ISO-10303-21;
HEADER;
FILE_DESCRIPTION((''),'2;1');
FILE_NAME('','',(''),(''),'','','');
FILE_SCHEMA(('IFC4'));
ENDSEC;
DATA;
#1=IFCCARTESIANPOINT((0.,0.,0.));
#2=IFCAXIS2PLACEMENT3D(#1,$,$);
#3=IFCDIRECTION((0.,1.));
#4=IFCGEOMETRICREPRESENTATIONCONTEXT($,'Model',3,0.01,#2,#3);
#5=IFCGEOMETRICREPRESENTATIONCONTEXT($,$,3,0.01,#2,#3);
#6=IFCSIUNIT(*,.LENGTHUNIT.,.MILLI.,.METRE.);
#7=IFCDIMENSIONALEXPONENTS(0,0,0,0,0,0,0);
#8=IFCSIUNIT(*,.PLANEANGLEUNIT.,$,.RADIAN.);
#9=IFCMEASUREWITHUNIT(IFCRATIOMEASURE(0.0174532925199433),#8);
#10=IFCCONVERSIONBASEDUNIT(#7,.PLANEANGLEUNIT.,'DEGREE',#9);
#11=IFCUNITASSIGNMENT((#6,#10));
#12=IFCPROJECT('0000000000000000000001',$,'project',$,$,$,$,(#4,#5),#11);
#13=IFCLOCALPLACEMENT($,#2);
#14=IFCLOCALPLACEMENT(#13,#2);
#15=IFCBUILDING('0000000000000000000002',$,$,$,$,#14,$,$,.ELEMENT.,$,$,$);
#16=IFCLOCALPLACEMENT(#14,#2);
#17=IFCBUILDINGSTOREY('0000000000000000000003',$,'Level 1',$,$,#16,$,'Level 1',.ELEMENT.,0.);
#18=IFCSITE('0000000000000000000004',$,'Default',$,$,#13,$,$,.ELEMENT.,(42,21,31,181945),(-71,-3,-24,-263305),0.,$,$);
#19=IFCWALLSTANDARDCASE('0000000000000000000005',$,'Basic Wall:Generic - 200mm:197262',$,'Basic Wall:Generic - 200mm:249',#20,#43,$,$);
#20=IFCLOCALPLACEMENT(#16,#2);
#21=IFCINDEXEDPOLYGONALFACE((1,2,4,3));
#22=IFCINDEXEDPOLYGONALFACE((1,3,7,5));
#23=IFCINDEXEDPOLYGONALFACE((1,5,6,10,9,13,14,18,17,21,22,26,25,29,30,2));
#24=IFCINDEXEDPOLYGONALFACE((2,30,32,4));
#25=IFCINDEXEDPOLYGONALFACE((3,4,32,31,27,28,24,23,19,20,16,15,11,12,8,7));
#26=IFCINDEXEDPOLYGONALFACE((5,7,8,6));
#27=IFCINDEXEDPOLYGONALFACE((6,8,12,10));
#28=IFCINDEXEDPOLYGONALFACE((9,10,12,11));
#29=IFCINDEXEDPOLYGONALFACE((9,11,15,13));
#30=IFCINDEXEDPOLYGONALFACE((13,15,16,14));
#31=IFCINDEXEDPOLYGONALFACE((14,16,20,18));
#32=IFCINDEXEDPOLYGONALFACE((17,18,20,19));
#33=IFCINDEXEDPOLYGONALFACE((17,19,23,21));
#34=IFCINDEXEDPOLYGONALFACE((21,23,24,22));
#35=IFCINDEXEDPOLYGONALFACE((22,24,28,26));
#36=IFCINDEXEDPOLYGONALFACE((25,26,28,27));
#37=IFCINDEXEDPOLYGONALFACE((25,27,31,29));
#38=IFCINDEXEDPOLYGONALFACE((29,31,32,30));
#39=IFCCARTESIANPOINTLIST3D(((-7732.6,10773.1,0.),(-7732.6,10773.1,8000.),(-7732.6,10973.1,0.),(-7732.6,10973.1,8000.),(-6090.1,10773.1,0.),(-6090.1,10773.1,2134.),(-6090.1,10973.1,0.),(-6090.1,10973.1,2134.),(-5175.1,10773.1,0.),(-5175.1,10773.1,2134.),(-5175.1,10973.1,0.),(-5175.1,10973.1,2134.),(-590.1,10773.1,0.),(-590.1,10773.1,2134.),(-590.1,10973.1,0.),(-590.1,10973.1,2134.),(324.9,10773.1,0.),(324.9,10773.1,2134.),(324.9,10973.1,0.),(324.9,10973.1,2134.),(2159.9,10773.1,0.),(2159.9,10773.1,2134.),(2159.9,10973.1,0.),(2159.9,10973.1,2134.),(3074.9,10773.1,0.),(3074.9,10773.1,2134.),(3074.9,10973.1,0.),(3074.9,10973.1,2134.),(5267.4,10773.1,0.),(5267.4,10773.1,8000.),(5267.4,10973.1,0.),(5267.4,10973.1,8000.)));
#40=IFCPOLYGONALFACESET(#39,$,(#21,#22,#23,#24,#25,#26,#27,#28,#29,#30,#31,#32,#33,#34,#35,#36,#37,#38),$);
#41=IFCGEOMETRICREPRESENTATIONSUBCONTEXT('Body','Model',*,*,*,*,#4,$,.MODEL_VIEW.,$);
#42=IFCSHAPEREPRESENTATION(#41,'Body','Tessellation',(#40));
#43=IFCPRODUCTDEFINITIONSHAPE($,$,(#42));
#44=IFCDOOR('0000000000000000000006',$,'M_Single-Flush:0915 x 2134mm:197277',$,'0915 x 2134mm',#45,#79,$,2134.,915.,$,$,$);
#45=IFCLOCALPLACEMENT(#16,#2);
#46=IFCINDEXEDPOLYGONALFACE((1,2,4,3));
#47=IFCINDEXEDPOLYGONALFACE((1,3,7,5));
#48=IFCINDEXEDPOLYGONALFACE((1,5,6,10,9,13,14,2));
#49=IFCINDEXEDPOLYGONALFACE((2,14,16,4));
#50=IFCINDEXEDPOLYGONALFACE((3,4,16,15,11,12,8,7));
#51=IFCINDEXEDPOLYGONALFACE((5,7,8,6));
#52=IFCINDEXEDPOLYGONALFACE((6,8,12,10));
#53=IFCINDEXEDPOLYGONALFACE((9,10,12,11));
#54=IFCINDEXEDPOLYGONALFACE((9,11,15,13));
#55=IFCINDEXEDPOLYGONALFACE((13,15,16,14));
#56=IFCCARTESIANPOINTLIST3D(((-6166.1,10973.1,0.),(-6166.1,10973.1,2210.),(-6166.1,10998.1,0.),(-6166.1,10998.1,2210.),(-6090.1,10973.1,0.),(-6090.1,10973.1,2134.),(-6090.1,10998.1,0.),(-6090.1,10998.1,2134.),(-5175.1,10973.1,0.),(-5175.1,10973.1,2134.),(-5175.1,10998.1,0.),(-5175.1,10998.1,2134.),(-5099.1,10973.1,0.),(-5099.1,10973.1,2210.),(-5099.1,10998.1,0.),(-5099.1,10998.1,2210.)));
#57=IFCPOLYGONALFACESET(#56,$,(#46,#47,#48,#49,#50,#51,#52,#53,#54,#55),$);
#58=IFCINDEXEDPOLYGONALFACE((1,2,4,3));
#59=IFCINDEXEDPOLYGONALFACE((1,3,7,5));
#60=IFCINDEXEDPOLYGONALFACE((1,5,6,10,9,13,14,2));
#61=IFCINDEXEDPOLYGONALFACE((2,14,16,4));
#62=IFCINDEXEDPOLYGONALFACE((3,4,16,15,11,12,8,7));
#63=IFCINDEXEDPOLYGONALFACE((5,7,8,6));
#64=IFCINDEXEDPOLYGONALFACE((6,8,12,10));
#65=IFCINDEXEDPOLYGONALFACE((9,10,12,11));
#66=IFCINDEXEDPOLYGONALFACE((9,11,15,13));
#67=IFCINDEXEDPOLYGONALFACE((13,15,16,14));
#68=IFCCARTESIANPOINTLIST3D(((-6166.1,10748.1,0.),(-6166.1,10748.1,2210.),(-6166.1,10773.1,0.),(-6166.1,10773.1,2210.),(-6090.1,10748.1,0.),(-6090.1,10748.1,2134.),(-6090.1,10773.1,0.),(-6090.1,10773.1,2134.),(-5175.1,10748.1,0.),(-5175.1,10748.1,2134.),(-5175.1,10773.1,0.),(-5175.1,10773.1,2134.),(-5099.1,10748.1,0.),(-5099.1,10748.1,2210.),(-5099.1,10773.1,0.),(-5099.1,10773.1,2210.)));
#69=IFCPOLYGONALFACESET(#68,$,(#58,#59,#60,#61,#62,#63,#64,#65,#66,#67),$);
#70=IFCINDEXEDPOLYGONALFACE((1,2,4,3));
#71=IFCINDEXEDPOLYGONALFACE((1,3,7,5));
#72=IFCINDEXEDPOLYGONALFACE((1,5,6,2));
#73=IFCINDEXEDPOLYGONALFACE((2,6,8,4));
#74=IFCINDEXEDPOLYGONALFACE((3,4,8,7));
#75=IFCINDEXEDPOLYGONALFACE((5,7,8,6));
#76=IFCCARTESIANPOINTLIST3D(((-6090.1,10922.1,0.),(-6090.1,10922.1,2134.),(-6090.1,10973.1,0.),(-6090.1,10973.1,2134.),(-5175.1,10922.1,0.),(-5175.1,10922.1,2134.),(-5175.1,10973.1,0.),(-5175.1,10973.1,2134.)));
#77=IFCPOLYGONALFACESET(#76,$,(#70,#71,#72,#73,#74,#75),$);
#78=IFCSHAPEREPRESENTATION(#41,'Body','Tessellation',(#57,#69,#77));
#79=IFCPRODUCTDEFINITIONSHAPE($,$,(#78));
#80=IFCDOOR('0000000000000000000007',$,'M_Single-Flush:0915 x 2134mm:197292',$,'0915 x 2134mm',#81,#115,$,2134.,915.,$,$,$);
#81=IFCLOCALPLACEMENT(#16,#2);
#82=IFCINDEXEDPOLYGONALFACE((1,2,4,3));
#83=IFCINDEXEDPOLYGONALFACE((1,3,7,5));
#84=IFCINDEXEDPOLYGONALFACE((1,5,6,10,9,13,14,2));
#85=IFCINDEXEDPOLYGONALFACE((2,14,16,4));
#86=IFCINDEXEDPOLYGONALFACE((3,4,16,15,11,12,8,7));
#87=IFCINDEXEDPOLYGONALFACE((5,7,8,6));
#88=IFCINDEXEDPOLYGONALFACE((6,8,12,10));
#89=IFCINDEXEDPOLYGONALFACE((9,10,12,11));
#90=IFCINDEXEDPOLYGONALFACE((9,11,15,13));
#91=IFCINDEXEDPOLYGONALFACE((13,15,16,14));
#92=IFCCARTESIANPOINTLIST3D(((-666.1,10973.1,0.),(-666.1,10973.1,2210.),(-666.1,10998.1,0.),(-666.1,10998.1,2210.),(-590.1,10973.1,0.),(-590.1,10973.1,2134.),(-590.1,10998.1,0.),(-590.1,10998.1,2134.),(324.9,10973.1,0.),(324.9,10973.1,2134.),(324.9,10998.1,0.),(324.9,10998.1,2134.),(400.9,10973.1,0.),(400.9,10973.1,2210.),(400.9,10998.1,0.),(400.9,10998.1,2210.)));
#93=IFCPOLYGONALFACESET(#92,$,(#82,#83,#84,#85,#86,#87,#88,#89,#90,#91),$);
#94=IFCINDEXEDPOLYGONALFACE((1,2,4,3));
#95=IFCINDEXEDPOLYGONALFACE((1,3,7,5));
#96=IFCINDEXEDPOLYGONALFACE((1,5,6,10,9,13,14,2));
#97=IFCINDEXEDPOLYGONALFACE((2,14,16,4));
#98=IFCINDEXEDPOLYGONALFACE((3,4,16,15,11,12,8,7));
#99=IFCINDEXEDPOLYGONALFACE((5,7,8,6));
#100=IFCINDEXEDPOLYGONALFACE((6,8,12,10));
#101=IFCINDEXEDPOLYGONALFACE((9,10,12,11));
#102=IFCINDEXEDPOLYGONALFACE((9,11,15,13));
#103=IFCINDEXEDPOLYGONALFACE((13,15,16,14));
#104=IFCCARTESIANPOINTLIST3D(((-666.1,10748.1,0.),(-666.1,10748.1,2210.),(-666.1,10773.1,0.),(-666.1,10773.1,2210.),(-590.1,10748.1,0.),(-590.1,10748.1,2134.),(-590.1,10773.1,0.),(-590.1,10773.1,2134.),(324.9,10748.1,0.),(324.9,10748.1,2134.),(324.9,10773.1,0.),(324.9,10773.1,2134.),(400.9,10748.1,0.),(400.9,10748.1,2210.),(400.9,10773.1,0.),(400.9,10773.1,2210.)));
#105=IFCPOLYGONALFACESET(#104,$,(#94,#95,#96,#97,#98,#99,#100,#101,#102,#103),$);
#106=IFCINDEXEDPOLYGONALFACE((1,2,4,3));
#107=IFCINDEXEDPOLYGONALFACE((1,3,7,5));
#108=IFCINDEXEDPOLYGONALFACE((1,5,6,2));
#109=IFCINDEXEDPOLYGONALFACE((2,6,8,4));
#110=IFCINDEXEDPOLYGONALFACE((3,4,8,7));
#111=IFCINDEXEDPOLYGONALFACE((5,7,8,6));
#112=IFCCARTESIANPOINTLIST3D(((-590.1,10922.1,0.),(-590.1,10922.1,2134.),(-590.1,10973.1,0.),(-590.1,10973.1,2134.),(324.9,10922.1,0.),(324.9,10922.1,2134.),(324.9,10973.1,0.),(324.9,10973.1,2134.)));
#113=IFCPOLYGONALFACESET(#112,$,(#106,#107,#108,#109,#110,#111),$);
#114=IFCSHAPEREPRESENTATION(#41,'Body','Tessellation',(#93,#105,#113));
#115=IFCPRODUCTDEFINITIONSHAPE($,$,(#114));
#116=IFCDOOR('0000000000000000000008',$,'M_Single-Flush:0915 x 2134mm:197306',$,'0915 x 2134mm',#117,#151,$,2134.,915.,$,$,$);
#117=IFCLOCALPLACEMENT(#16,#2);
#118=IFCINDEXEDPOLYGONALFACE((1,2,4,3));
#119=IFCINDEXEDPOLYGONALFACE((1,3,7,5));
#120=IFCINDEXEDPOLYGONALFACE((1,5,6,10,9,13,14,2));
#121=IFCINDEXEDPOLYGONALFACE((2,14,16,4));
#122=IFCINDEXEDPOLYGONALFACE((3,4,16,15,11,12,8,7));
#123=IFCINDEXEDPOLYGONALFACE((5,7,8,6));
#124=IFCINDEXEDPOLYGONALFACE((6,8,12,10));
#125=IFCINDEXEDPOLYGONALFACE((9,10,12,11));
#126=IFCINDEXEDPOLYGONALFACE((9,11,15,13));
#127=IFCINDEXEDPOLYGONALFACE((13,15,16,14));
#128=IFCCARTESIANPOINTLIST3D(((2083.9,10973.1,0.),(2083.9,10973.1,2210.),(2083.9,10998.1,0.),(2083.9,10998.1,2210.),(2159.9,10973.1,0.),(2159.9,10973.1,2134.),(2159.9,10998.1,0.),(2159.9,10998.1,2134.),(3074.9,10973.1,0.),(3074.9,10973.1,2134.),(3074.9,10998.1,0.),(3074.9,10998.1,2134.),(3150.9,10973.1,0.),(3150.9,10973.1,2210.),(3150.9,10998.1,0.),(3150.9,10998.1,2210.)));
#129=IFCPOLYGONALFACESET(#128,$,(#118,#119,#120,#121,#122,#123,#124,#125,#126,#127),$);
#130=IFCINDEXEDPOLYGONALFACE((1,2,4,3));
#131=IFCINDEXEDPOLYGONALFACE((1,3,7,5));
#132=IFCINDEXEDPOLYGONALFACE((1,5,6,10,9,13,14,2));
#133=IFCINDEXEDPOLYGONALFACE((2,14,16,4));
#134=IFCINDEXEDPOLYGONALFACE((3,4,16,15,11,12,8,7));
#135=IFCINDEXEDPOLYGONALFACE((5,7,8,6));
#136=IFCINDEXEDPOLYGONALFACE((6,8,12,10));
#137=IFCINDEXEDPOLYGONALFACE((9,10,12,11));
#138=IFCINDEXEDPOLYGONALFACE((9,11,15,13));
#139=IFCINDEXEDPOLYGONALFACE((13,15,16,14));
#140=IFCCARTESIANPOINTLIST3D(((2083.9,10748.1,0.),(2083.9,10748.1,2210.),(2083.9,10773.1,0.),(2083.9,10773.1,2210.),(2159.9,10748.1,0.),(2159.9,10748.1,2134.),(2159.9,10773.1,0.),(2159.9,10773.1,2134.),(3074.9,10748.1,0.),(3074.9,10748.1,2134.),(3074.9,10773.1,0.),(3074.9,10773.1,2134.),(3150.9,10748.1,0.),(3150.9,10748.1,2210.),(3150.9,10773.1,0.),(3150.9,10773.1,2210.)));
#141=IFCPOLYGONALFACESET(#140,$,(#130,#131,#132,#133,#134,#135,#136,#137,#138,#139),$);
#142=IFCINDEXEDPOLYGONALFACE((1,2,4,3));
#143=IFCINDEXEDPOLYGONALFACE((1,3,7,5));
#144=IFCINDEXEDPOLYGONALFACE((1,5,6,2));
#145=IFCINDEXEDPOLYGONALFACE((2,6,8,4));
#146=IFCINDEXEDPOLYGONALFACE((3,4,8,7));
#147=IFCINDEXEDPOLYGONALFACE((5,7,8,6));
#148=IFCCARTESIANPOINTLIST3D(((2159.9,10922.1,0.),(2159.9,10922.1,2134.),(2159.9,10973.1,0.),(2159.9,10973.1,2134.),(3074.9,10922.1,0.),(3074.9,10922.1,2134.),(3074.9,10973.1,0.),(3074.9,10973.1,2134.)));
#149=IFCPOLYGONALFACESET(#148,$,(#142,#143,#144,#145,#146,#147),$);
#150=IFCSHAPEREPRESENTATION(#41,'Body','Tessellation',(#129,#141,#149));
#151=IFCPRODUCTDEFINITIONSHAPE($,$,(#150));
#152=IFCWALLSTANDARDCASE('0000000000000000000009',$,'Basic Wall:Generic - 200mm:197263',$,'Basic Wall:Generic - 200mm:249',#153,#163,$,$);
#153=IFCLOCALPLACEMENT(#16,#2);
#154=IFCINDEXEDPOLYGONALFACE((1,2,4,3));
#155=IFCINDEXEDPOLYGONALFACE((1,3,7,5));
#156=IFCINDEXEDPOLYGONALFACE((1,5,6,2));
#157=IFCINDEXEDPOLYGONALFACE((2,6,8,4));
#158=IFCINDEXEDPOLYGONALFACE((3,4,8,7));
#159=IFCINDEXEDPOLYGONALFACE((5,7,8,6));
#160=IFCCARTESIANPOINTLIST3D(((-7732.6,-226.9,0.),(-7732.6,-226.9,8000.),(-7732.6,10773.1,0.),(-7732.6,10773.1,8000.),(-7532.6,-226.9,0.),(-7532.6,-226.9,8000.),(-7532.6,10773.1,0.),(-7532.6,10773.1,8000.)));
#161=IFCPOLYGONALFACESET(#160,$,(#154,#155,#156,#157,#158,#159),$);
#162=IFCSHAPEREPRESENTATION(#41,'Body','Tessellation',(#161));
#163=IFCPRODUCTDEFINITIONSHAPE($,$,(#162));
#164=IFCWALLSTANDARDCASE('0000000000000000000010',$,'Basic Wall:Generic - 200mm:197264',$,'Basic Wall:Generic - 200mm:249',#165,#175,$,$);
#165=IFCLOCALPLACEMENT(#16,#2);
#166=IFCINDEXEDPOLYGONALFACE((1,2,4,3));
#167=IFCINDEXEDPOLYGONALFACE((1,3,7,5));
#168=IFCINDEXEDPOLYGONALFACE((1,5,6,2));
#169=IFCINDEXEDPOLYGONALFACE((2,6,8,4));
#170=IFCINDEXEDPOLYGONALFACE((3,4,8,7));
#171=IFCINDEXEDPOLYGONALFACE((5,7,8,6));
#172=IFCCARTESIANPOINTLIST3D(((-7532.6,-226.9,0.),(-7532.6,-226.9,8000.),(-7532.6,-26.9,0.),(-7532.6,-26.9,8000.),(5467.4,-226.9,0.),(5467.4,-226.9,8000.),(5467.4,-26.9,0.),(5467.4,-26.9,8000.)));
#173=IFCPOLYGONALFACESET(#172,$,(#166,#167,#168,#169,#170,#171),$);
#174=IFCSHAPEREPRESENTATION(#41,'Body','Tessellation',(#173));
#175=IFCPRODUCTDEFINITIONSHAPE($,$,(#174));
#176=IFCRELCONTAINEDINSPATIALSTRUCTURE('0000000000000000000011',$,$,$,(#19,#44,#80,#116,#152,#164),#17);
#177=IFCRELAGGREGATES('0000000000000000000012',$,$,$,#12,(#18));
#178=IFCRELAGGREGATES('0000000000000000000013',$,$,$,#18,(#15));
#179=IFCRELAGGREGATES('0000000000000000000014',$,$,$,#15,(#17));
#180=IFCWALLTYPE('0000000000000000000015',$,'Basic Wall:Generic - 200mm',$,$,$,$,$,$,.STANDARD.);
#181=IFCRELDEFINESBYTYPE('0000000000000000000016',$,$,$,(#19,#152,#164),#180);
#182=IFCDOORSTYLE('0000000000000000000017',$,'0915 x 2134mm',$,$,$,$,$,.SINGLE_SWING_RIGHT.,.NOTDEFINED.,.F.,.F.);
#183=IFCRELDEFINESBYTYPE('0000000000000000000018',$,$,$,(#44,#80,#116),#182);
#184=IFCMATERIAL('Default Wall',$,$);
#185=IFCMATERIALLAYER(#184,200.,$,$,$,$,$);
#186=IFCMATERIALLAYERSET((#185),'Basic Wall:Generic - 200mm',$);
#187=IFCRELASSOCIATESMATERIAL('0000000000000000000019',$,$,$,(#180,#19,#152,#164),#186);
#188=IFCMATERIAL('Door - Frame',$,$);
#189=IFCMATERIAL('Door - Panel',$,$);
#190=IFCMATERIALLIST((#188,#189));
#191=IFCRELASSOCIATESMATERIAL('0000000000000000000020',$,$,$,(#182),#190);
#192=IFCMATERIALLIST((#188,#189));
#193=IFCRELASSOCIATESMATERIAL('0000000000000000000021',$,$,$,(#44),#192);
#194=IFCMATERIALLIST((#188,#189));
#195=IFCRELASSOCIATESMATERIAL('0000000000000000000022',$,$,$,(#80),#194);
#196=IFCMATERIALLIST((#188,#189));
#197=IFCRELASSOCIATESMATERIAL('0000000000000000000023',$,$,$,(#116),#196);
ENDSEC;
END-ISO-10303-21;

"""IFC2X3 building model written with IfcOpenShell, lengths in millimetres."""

from ifc_helpers import new_model, entity, si_unit, converted_unit, direction, frame, frame_2d, origin, place, context, subcontext, project, spatial, polyline, rectangle, outline, extrude, source, transform, mapped, material, material_list, layer, layer_set, layer_usage, type_object, type_shapes, element, fill, save


model = new_model("IFC2X3")

# Units and contexts
model_context = context("Model", 3, precision=0.01, world=origin(), true_north=direction((0.0, 1.0)))
context_of_model = context(None, 3, precision=0.01, world=origin(), true_north=direction((0.0, 1.0)))
body_context = subcontext(model_context, "Body", "Model", "MODEL_VIEW")
ifc_project = project(units=[si_unit("LENGTHUNIT", "METRE", prefix="MILLI"), converted_unit("PLANEANGLEUNIT", "DEGREE", entity("IfcRatioMeasure", 0.0174532925199433), si_unit("PLANEANGLEUNIT", "RADIAN"), dimensions=[0, 0, 0, 0, 0, 0, 0])], contexts=[model_context, context_of_model])

# Site, building, storey
site_placement = place(None, origin())
site = spatial("IfcSite", under=ifc_project, at=site_placement, Name="Default", CompositionType="ELEMENT", RefLatitude=(42, 21, 31, 181945), RefLongitude=(-71, -3, -24, -263305), RefElevation=0.0)
building_placement = place(site_placement, origin())
building = spatial("IfcBuilding", under=site, at=building_placement, CompositionType="ELEMENT")
storey_placement = place(building_placement, origin())
storey = spatial("IfcBuildingStorey", under=building, at=storey_placement, Name="Level 1", LongName="Level 1", CompositionType="ELEMENT", Elevation=0.0)

# Wall, openings, doors
ifc_material_1 = material(Name="Default Wall")
ifc_layer = layer(ifc_material_1, 200.0)
ifc_layer_set = layer_set([ifc_layer], Name="Basic Wall:Generic - 200mm")
ifc_layer_usage_1 = layer_usage(ifc_layer_set, "AXIS2", "NEGATIVE", 100.0)
wall_type = type_object("IfcWallType", Name="Basic Wall:Generic - 200mm", PredefinedType="STANDARD", material=ifc_layer_set)
wall_1_placement = place(storey_placement, frame((-7732.6, 10873.1, 0.0)))
wall_1 = element("IfcWallStandardCase", 1, at=wall_1_placement, inside=storey, type_object=wall_type, material=ifc_layer_usage_1, Name="Basic Wall:Generic - 200mm:197262", ObjectType="Basic Wall:Generic - 200mm:249", context=body_context, shape_type="SweptSolid", body=[
    extrude(rectangle(XDim=13000.0, YDim=200.0, at=frame_2d((6500.0, 0.0), x_axis=(-1.0, 0.0))), origin(), (0.0, 0.0, 1.0), 8000.0),
])
opening_1_placement = place(wall_1_placement, frame((1642.5, -100.0, 0.0)))
opening_1 = element("IfcOpeningElement", 2, at=opening_1_placement, cuts=wall_1, ObjectType="Opening", context=body_context, shape_type="SweptSolid", body=[
    extrude(rectangle(XDim=915.0, YDim=2134.0, at=frame_2d((1067.0, 457.5), x_axis=(0.0, 1.0))), frame((0.0, 0.0, 0.0), z_axis=(0.0, 1.0, 0.0), x_axis=(0.0, 0.0, 1.0)), (0.0, 0.0, 1.0), 200.0),
])
opening_2_placement = place(wall_1_placement, frame((7142.5, -100.0, 0.0)))
opening_2 = element("IfcOpeningElement", 3, at=opening_2_placement, cuts=wall_1, ObjectType="Opening", context=body_context, shape_type="SweptSolid", body=[
    extrude(rectangle(XDim=915.0, YDim=2134.0, at=frame_2d((1067.0, 457.5), x_axis=(0.0, 1.0))), frame((0.0, 0.0, 0.0), z_axis=(0.0, 1.0, 0.0), x_axis=(0.0, 0.0, 1.0)), (0.0, 0.0, 1.0), 200.0),
])
opening_3_placement = place(wall_1_placement, frame((9892.5, -100.0, 0.0)))
opening_3 = element("IfcOpeningElement", 4, at=opening_3_placement, cuts=wall_1, ObjectType="Opening", context=body_context, shape_type="SweptSolid", body=[
    extrude(rectangle(XDim=915.0, YDim=2134.0, at=frame_2d((1067.0, 457.5), x_axis=(0.0, 1.0))), frame((0.0, 0.0, 0.0), z_axis=(0.0, 1.0, 0.0), x_axis=(0.0, 0.0, 1.0)), (0.0, 0.0, 1.0), 200.0),
])
ifc_material_2 = material(Name="Door - Frame")
ifc_material_3 = material(Name="Door - Panel")
ifc_material_list_1 = material_list([ifc_material_2, ifc_material_3])
ifc_material_list_2 = material_list([ifc_material_2, ifc_material_3])
door_style = type_object("IfcDoorStyle", Name="0915 x 2134mm", ConstructionType="NOTDEFINED", OperationType="SINGLE_SWING_RIGHT", ParameterTakesPrecedence=False, Sizeable=False, material=ifc_material_list_2)
shared_shape = source(origin(), body_context, "Body", "SweptSolid", [
    extrude(outline(polyline([(-533.5, -1124.0), (533.5, -1124.0), (533.5, 1086.0), (457.5, 1086.0), (457.5, -1048.0), (-457.5, -1048.0), (-457.5, 1086.0), (-533.5, 1086.0), (-533.5, -1124.0)])), frame((457.5, 200.0, 1086.0), z_axis=(0.0, 1.0, 0.0), x_axis=(1.0, 0.0, 0.0)), (0.0, 0.0, 1.0), 25.0),
    extrude(outline(polyline([(-1124.0, -533.5), (1086.0, -533.5), (1086.0, -457.5), (-1048.0, -457.5), (-1048.0, 457.5), (1086.0, 457.5), (1086.0, 533.5), (-1124.0, 533.5), (-1124.0, -533.5)])), frame((457.5, -25.0, 1086.0), z_axis=(0.0, 1.0, 0.0), x_axis=(0.0, 0.0, -1.0)), (0.0, 0.0, 1.0), 25.0),
    extrude(rectangle(XDim=51.0, YDim=915.0, at=frame_2d((0.0, 0.0), x_axis=(1.0, 0.0))), frame((457.5, 174.5, 0.0), z_axis=(0.0, 0.0, 1.0), x_axis=(0.0, 1.0, 0.0)), (0.0, 0.0, 1.0), 2134.0),
])
type_shapes(door_style, [shared_shape])
door_1_placement = place(opening_1_placement, origin())
door_1 = element("IfcDoor", 5, at=door_1_placement, inside=storey, type_object=door_style, material=ifc_material_list_1, Name="M_Single-Flush:0915 x 2134mm:197277", ObjectType="0915 x 2134mm", OverallHeight=2134.0, OverallWidth=915.0, context=body_context, shape_type="MappedRepresentation", body=[
    mapped(shared_shape, transform((0.0, 0.0, 0.0), scale=1.0)),
])
fill(opening_1, door_1)
ifc_material_list_3 = material_list([ifc_material_2, ifc_material_3])
door_2_placement = place(opening_2_placement, origin())
door_2 = element("IfcDoor", 6, at=door_2_placement, inside=storey, type_object=door_style, material=ifc_material_list_3, Name="M_Single-Flush:0915 x 2134mm:197292", ObjectType="0915 x 2134mm", OverallHeight=2134.0, OverallWidth=915.0, context=body_context, shape_type="MappedRepresentation", body=[
    mapped(shared_shape, transform((0.0, 0.0, 0.0), scale=1.0)),
])
fill(opening_2, door_2)
ifc_material_list_4 = material_list([ifc_material_2, ifc_material_3])
door_3_placement = place(opening_3_placement, origin())
door_3 = element("IfcDoor", 7, at=door_3_placement, inside=storey, type_object=door_style, material=ifc_material_list_4, Name="M_Single-Flush:0915 x 2134mm:197306", ObjectType="0915 x 2134mm", OverallHeight=2134.0, OverallWidth=915.0, context=body_context, shape_type="MappedRepresentation", body=[
    mapped(shared_shape, transform((0.0, 0.0, 0.0), scale=1.0)),
])
fill(opening_3, door_3)

# Walls
ifc_layer_usage_2 = layer_usage(ifc_layer_set, "AXIS2", "NEGATIVE", 100.0)
wall_2_placement = place(storey_placement, frame((-7632.6, -226.9, 0.0), z_axis=(0.0, 0.0, 1.0), x_axis=(0.0, 1.0, 0.0)))
element("IfcWallStandardCase", 8, at=wall_2_placement, inside=storey, type_object=wall_type, material=ifc_layer_usage_2, Name="Basic Wall:Generic - 200mm:197263", ObjectType="Basic Wall:Generic - 200mm:249", context=body_context, shape_type="SweptSolid", body=[
    extrude(rectangle(XDim=11000.0, YDim=200.0, at=frame_2d((5500.0, 0.0), x_axis=(-1.0, 0.0))), origin(), (0.0, 0.0, 1.0), 8000.0),
])
ifc_layer_usage_3 = layer_usage(ifc_layer_set, "AXIS2", "NEGATIVE", 100.0)
wall_3_placement = place(storey_placement, frame((5467.4, -126.9, 0.0), z_axis=(0.0, 0.0, 1.0), x_axis=(-1.0, 0.0, 0.0)))
element("IfcWallStandardCase", 9, at=wall_3_placement, inside=storey, type_object=wall_type, material=ifc_layer_usage_3, Name="Basic Wall:Generic - 200mm:197264", ObjectType="Basic Wall:Generic - 200mm:249", context=body_context, shape_type="SweptSolid", body=[
    extrude(rectangle(XDim=13000.0, YDim=200.0, at=frame_2d((6500.0, 0.0), x_axis=(-1.0, 0.0))), origin(), (0.0, 0.0, 1.0), 8000.0),
])

save(model, "model.ifc")
